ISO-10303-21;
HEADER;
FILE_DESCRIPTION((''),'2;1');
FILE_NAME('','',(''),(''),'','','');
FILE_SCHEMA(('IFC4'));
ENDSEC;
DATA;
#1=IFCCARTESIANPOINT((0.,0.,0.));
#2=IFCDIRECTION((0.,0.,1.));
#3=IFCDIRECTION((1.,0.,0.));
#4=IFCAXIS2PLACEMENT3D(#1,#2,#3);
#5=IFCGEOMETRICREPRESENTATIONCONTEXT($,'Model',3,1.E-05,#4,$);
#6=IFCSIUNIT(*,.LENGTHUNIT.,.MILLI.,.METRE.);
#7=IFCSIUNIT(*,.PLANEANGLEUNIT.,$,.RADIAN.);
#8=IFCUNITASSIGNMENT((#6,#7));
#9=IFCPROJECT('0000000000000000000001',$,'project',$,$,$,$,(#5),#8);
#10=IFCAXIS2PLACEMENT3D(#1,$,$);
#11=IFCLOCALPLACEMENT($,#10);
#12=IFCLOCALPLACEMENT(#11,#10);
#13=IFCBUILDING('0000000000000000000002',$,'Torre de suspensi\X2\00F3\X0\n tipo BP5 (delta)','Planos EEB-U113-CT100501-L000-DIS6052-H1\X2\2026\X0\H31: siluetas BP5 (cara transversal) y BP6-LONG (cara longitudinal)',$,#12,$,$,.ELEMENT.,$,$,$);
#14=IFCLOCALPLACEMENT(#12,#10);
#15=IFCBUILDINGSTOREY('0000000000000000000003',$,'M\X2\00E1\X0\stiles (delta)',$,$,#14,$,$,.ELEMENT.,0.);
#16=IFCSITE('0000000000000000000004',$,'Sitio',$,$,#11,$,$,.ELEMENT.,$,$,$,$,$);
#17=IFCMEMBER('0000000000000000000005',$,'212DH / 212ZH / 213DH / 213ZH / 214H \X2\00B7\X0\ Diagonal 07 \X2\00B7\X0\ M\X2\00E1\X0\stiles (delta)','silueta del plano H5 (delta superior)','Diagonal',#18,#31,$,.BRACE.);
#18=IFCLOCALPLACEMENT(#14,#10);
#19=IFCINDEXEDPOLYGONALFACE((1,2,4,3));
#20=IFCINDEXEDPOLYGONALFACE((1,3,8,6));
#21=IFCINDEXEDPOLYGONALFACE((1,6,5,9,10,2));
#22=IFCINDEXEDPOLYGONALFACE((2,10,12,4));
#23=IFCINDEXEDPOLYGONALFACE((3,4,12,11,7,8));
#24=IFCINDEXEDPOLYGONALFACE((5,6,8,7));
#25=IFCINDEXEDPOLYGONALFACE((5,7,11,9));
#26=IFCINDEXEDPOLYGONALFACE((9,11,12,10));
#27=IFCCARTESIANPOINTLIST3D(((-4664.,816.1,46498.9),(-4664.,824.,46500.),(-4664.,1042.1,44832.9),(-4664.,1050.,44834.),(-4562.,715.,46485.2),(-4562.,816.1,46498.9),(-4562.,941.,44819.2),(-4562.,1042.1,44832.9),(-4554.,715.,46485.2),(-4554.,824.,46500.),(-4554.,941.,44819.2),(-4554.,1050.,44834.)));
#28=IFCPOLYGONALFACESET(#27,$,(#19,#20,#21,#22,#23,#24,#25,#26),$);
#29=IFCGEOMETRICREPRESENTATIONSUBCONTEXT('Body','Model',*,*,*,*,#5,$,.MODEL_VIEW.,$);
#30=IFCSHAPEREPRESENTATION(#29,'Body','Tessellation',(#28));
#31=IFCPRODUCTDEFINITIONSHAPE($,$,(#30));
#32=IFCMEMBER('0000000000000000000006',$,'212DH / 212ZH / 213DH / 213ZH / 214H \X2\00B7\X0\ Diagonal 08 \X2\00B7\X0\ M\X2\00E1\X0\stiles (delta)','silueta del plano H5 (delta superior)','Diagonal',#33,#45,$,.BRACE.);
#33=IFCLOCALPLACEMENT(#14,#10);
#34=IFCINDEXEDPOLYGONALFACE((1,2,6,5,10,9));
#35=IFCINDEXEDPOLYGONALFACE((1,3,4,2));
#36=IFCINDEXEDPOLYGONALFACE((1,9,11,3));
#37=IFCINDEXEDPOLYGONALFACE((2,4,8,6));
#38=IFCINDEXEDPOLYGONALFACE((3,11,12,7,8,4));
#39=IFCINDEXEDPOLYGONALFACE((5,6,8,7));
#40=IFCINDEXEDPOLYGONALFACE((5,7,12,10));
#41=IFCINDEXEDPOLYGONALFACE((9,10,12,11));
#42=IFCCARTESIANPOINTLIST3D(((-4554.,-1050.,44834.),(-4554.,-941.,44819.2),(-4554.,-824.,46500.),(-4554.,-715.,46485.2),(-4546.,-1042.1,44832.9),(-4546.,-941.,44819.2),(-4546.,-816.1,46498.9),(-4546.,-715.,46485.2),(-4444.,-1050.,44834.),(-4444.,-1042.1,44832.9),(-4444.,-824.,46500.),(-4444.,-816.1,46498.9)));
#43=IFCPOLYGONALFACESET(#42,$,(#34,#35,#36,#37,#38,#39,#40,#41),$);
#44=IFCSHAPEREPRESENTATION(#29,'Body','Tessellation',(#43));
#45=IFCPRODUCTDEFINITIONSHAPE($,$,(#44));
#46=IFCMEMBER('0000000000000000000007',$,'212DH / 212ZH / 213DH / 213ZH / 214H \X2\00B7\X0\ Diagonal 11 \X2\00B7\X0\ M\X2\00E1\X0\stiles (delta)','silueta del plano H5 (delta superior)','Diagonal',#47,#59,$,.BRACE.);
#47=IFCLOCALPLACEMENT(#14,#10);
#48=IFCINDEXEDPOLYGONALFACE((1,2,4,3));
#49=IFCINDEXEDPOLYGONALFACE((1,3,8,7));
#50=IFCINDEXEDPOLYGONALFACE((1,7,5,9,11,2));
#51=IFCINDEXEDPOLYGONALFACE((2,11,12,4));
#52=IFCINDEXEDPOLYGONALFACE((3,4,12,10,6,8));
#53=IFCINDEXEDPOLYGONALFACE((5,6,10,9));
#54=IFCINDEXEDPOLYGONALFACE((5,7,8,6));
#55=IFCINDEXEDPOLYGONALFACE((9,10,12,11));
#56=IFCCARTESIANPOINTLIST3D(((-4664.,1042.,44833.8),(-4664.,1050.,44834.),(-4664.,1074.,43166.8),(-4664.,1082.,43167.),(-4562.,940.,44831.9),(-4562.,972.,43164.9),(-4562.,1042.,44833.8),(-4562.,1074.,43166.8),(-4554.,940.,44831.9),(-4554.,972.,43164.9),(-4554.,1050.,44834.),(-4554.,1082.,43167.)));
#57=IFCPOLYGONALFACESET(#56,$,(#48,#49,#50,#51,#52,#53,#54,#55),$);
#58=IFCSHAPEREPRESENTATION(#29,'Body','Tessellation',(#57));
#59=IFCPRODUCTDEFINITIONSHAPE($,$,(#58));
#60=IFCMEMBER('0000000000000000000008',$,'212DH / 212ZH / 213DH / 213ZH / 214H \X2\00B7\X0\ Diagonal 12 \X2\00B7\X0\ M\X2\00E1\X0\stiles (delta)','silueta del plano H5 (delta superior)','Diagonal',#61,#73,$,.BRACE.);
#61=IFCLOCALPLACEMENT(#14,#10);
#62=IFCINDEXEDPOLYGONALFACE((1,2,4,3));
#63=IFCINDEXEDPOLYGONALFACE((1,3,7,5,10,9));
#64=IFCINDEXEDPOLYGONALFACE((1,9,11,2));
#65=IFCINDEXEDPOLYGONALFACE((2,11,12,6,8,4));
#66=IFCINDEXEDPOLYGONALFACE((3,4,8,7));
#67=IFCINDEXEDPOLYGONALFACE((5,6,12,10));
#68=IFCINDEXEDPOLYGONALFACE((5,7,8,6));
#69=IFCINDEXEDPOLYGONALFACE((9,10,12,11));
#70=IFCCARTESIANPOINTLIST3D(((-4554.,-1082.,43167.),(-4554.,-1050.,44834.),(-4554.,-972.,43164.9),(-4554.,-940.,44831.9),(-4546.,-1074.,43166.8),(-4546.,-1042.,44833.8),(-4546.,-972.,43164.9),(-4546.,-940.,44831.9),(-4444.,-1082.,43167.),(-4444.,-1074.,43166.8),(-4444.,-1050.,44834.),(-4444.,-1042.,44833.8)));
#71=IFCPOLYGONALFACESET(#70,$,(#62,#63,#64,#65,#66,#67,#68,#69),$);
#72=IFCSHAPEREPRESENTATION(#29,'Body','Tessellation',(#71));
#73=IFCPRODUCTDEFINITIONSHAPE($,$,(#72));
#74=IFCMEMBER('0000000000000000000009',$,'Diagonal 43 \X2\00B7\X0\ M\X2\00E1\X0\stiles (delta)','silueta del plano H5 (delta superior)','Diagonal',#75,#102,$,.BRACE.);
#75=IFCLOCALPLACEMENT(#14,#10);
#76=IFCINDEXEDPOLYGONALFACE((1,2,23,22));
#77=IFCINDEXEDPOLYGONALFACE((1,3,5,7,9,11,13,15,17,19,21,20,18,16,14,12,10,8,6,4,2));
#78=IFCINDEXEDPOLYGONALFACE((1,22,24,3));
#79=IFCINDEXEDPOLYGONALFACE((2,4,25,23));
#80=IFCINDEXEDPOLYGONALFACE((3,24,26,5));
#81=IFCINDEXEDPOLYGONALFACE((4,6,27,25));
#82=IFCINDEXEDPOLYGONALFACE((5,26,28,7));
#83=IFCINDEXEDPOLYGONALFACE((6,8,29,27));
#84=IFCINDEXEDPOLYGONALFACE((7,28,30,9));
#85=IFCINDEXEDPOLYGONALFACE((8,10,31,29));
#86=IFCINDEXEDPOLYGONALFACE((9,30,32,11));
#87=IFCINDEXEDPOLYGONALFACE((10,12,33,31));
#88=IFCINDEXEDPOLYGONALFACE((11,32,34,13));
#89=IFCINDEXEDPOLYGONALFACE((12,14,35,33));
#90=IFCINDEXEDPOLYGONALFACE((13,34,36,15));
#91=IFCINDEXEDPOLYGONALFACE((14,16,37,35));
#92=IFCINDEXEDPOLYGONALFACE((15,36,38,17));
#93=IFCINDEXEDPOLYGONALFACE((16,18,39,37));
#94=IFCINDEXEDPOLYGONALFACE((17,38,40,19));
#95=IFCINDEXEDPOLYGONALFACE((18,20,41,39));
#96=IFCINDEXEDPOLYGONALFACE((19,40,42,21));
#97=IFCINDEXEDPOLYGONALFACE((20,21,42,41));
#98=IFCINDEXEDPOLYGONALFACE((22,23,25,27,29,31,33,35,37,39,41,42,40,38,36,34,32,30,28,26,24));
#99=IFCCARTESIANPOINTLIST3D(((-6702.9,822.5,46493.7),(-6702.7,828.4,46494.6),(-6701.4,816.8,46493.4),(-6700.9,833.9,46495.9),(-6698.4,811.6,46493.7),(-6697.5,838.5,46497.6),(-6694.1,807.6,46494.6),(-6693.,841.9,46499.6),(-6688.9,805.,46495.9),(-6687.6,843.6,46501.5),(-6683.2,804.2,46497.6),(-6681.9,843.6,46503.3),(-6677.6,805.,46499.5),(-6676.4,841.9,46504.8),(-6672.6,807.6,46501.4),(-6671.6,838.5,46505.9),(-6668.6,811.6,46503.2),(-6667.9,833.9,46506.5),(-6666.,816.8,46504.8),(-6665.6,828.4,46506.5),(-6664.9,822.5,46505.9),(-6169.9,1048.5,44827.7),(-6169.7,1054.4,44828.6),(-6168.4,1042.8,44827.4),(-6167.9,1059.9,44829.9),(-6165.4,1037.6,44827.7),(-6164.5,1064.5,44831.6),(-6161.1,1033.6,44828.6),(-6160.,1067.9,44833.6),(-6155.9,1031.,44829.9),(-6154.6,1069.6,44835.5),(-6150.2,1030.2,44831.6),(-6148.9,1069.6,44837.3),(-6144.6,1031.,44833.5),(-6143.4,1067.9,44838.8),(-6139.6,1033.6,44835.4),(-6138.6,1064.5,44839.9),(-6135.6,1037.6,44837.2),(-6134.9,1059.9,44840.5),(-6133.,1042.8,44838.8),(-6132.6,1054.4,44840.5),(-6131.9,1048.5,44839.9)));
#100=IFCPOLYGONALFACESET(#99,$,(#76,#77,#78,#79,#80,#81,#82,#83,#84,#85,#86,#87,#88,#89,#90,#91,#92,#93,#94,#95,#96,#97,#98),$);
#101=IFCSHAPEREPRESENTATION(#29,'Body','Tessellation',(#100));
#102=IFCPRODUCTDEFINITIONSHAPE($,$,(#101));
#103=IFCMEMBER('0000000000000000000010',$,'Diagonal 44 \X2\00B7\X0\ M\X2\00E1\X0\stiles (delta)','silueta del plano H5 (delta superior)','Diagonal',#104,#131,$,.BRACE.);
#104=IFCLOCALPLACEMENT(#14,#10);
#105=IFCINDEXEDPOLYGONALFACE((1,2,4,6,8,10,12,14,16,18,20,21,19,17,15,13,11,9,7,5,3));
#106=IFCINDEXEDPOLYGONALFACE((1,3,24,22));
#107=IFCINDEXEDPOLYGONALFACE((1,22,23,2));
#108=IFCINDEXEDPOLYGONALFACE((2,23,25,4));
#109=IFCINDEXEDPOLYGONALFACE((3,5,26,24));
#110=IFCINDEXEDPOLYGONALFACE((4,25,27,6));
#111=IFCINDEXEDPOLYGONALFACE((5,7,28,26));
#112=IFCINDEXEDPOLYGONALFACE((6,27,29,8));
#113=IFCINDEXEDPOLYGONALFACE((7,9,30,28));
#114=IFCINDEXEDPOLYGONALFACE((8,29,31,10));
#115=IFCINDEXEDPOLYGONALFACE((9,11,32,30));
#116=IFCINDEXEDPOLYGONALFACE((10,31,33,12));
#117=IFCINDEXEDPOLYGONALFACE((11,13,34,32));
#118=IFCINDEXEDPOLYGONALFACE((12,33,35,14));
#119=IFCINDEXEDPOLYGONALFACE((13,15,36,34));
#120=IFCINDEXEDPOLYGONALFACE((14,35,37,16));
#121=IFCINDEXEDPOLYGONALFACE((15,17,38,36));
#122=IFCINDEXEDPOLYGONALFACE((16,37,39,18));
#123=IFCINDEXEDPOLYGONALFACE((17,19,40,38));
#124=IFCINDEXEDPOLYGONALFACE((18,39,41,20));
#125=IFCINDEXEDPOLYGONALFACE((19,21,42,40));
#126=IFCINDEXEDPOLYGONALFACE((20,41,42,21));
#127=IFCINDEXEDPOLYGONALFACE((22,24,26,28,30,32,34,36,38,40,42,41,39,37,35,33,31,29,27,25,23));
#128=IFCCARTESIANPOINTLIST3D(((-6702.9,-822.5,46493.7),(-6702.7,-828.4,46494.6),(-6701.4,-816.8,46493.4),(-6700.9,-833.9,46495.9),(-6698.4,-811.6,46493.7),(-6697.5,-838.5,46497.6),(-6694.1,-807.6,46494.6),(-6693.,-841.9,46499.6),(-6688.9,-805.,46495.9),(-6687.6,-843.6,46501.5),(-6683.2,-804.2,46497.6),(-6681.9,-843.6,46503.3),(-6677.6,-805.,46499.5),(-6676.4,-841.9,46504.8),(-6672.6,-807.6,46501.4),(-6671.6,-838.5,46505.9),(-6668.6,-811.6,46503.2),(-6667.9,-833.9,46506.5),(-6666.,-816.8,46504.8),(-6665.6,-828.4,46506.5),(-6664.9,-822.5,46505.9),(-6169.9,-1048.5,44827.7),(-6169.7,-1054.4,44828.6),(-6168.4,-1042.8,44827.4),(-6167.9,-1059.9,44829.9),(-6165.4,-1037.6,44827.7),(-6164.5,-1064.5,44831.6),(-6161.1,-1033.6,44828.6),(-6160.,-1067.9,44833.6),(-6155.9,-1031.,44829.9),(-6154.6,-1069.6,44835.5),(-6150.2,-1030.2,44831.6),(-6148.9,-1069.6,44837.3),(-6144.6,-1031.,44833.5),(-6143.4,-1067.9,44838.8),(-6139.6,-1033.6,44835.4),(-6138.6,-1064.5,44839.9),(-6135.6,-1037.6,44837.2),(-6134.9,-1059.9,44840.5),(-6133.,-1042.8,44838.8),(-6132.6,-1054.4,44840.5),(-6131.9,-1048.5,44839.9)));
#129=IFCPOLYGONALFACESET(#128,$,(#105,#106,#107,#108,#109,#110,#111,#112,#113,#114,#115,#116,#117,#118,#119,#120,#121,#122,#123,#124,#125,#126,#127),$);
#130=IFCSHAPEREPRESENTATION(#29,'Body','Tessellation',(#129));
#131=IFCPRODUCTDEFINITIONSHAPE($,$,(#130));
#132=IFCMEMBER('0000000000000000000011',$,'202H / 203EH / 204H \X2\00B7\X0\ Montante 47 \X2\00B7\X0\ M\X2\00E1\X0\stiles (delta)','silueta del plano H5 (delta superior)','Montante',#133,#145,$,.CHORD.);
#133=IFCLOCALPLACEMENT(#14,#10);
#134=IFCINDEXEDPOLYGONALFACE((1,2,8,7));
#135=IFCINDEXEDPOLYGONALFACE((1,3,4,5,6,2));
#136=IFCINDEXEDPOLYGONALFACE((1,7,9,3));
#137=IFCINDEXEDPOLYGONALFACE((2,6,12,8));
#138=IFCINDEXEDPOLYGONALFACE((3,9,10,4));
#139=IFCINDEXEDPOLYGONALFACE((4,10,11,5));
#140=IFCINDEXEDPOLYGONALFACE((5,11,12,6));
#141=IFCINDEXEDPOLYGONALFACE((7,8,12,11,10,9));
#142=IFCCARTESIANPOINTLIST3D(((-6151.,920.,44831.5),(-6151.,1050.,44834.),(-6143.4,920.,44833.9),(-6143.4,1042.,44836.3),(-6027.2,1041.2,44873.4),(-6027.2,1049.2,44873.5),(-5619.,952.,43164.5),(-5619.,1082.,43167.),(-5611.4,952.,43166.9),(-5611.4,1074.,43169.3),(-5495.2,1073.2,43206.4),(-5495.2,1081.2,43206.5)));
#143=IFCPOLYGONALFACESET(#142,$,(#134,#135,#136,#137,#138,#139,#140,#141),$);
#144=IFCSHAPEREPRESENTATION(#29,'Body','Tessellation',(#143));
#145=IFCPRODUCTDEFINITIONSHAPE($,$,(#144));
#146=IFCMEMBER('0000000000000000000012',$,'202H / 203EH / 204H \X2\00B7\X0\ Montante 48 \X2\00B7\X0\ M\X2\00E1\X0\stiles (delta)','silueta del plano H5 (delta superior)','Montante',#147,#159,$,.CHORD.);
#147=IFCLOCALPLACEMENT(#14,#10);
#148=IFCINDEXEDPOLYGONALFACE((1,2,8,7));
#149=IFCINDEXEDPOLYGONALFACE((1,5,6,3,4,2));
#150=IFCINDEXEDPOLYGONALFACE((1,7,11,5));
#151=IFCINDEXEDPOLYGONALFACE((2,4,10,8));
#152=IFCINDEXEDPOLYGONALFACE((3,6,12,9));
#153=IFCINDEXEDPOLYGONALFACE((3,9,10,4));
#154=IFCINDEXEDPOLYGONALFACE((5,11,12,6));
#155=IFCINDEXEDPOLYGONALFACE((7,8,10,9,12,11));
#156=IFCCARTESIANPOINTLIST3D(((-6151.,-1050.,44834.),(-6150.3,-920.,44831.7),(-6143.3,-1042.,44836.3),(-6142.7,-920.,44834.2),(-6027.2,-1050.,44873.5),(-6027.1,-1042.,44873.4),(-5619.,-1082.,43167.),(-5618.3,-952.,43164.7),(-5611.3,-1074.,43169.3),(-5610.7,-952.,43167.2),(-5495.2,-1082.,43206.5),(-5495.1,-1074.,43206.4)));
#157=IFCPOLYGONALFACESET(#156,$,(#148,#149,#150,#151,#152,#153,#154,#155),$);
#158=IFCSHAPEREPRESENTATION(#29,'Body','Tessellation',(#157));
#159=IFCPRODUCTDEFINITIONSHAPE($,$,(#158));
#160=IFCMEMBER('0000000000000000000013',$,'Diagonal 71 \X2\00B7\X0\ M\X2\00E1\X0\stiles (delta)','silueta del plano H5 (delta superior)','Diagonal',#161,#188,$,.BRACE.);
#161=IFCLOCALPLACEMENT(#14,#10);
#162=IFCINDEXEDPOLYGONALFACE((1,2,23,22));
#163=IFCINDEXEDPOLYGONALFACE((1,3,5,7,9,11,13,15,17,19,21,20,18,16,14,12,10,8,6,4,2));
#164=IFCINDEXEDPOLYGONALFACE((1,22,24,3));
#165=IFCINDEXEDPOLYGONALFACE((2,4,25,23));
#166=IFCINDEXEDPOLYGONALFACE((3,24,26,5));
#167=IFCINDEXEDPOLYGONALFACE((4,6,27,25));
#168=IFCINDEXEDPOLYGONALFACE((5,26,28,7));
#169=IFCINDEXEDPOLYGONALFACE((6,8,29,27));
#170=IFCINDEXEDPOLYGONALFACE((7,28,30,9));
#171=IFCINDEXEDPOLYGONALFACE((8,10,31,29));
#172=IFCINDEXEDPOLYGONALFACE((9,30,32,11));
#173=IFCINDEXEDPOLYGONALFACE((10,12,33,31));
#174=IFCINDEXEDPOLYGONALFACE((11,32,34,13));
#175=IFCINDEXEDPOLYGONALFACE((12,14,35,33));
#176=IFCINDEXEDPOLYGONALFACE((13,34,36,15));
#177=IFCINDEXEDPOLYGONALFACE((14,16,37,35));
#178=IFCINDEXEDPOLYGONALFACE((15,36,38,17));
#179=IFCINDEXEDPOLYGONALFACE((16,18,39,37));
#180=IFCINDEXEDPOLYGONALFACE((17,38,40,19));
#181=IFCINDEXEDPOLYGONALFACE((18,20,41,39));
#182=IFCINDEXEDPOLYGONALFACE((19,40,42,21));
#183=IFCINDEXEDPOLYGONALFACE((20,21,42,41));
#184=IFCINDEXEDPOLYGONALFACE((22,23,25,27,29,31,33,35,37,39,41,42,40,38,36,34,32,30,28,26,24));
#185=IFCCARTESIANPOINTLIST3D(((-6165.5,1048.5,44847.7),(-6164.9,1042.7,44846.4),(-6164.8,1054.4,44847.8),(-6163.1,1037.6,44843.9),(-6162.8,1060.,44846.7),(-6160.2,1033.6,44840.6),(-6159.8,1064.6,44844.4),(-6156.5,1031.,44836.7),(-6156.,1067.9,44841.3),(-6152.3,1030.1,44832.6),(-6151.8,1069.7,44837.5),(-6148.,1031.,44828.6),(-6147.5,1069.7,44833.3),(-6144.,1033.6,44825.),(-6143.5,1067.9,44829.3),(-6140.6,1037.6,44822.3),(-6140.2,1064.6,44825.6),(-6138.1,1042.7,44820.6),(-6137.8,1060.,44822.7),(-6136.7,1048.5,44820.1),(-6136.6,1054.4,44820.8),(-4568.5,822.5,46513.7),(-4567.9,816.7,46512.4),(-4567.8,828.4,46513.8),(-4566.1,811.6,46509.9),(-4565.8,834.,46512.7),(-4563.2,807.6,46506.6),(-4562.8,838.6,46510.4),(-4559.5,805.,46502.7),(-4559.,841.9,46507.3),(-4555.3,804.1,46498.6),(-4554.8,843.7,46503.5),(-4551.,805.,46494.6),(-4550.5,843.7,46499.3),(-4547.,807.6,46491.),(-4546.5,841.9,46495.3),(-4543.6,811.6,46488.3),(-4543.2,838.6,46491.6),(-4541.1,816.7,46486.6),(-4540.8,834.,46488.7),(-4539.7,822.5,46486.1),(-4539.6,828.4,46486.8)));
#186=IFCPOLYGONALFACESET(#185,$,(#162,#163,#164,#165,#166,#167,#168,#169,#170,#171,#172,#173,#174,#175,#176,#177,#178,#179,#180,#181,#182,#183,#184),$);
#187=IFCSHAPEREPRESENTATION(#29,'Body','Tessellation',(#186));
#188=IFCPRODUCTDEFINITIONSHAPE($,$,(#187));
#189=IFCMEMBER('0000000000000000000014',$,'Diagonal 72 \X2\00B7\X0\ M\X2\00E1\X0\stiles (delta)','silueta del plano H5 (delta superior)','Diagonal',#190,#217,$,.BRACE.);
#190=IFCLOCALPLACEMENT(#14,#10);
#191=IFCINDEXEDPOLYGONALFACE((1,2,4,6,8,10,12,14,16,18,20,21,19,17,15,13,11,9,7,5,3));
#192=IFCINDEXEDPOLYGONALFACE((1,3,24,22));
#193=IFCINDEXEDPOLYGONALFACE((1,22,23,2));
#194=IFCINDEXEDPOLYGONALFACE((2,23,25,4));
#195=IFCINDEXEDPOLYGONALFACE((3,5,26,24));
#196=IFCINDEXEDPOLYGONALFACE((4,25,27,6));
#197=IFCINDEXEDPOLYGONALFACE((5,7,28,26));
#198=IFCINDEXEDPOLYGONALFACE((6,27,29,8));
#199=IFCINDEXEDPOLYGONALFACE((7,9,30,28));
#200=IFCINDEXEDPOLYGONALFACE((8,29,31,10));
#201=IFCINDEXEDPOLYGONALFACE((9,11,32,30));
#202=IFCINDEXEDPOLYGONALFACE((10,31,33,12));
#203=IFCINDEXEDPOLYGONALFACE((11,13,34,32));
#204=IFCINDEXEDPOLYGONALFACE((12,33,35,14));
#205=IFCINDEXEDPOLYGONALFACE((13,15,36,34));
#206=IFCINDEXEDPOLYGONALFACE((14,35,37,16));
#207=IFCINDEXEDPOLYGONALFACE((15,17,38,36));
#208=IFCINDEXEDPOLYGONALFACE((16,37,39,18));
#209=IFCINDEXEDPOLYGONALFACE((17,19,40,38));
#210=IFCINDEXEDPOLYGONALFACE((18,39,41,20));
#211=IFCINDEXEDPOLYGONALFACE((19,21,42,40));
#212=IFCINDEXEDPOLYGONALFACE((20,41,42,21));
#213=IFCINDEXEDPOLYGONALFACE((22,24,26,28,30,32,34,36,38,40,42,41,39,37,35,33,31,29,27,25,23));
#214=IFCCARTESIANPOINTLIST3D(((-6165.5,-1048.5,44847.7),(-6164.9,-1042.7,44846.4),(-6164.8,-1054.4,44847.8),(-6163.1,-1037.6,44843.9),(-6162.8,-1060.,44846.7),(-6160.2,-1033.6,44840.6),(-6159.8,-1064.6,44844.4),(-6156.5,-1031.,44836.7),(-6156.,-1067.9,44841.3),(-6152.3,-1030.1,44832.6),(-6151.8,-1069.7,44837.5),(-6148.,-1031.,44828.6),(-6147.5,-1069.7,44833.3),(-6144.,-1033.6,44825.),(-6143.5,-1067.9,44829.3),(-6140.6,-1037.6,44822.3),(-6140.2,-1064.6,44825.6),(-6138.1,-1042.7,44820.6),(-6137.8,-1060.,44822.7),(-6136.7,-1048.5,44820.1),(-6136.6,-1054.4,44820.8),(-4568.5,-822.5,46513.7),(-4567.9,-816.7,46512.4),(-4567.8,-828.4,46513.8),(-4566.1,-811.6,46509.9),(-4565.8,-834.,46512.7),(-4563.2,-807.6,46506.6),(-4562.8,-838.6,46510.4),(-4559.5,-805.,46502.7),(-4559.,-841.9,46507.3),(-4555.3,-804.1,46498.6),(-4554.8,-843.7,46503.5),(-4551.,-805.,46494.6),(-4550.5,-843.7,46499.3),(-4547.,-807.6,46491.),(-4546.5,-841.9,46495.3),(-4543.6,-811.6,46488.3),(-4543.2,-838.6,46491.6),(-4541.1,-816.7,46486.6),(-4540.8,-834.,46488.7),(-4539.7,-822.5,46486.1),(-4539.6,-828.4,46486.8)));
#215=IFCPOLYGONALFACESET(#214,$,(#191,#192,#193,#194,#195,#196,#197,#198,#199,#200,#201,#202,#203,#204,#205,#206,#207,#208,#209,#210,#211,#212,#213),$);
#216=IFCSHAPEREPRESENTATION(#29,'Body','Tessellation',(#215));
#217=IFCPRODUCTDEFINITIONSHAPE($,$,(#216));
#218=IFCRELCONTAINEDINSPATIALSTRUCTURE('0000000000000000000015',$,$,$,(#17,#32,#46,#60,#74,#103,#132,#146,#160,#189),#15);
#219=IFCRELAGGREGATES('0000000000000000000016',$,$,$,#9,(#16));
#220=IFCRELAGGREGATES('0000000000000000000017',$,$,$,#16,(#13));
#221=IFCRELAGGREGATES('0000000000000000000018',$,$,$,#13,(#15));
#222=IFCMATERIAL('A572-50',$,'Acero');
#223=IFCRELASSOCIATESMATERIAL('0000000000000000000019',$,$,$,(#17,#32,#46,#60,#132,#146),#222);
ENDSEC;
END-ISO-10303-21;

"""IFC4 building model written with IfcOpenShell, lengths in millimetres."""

from ifc_helpers import new_model, si_unit, frame, frame_2d, origin, origin_with_axes, place, context, subcontext, project, spatial, circle, l_section, extrude, material, element, save


model = new_model("IFC4")

# Units and contexts
model_context = context("Model", 3, precision=1e-05, world=origin_with_axes())
body_context = subcontext(model_context, "Body", "Model", "MODEL_VIEW")
ifc_project = project(units=[si_unit("LENGTHUNIT", "METRE", prefix="MILLI"), si_unit("PLANEANGLEUNIT", "RADIAN")], contexts=[model_context])

# Site, building, storey
site_placement = place(None, origin())
site = spatial("IfcSite", under=ifc_project, at=site_placement, Name="Sitio", CompositionType="ELEMENT")
building_placement = place(site_placement, origin())
building = spatial("IfcBuilding", under=site, at=building_placement, Name="Torre de suspensión tipo BP5 (delta)", Description="Planos EEB-U113-CT100501-L000-DIS6052-H1…H31: siluetas BP5 (cara transversal) y BP6-LONG (cara longitudinal)", CompositionType="ELEMENT")
storey_placement = place(building_placement, origin())
storey = spatial("IfcBuildingStorey", under=building, at=storey_placement, Name="Mástiles (delta)", CompositionType="ELEMENT", Elevation=0.0)

# Members
ifc_material = material(Name="A572-50", Category="Acero")
for number, where, z_axis, x_axis, name in (
    (1, (-4554.0, 824.0, 46500.0), (0.0, 0.134423, -0.990924), (0.0, -0.990924, -0.134423), "212DH / 212ZH / 213DH / 213ZH / 214H · Diagonal 07 · Mástiles (delta)"),
    (2, (-4554.0, -824.0, 46500.0), (0.0, -0.134423, -0.990924), (0.0, 0.990924, -0.134423), "212DH / 212ZH / 213DH / 213ZH / 214H · Diagonal 08 · Mástiles (delta)"),
):
    element("IfcMember", number, at=place(storey_placement, frame(where, z_axis=z_axis, x_axis=x_axis)), inside=storey, material=ifc_material, Name=name, Description="silueta del plano H5 (delta superior)", ObjectType="Diagonal", PredefinedType="BRACE", context=body_context, shape_type="SweptSolid", body=[
        extrude(l_section(Depth=110.0, Width=110.0, Thickness=8.0, at=frame_2d((55.0, 55.0))), None, (0.0, 0.0, 1.0), 1681.3),
    ])
for number, where, z_axis, x_axis, name in (
    (3, (-4554.0, 1050.0, 44834.0), (0.0, 0.019193, -0.999816), (0.0, -0.999816, -0.019193), "212DH / 212ZH / 213DH / 213ZH / 214H · Diagonal 11 · Mástiles (delta)"),
    (4, (-4554.0, -1050.0, 44834.0), (0.0, -0.019193, -0.999816), (0.0, 0.999816, -0.019193), "212DH / 212ZH / 213DH / 213ZH / 214H · Diagonal 12 · Mástiles (delta)"),
):
    element("IfcMember", number, at=place(storey_placement, frame(where, z_axis=z_axis, x_axis=x_axis)), inside=storey, material=ifc_material, Name=name, Description="silueta del plano H5 (delta superior)", ObjectType="Diagonal", PredefinedType="BRACE", context=body_context, shape_type="SweptSolid", body=[
        extrude(l_section(Depth=110.0, Width=110.0, Thickness=8.0, at=frame_2d((55.0, 55.0))), None, (0.0, 0.0, 1.0), 1667.3),
    ])
for number, where, z_axis, x_axis, name in (
    (5, (-6684.0, 824.0, 46500.0), (0.302202, 0.128138, -0.944592), (0.039045, -0.991756, -0.122044), "Diagonal 43 · Mástiles (delta)"),
    (6, (-6684.0, -824.0, 46500.0), (0.302202, -0.128138, -0.944592), (0.039045, 0.991756, -0.122044), "Diagonal 44 · Mástiles (delta)"),
):
    element("IfcMember", number, at=place(storey_placement, frame(where, z_axis=z_axis, x_axis=x_axis)), inside=storey, Name=name, Description="silueta del plano H5 (delta superior)", ObjectType="Diagonal", PredefinedType="BRACE", context=body_context, shape_type="SweptSolid", body=[
        extrude(circle(Radius=20.0), None, (0.0, 0.0, 1.0), 1763.7),
    ])
for number, where, z_axis, x_axis, name in (
    (7, (-6151.0, 1050.0, 44834.0), (0.303978, 0.018284, -0.952503), (0.952679, -0.005834, 0.303922), "202H / 203EH / 204H · Montante 47 · Mástiles (delta)"),
    (8, (-6151.0, -1050.0, 44834.0), (0.303978, -0.018284, -0.952503), (0.005559, 0.999833, -0.017419), "202H / 203EH / 204H · Montante 48 · Mástiles (delta)"),
):
    element("IfcMember", number, at=place(storey_placement, frame(where, z_axis=z_axis, x_axis=x_axis)), inside=storey, material=ifc_material, Name=name, Description="silueta del plano H5 (delta superior)", ObjectType="Montante", PredefinedType="CHORD", context=body_context, shape_type="SweptSolid", body=[
        extrude(l_section(Depth=130.0, Width=130.0, Thickness=8.0, at=frame_2d((65.0, 65.0))), None, (0.0, 0.0, 1.0), 1750.1),
    ])
for number, where, z_axis, x_axis, name in (
    (9, (-4554.0, 824.0, 46500.0), (-0.688705, 0.097462, -0.718461), (-0.067444, -0.995239, -0.070358), "Diagonal 71 · Mástiles (delta)"),
    (10, (-4554.0, -824.0, 46500.0), (-0.688705, -0.097462, -0.718461), (-0.067444, 0.995239, -0.070358), "Diagonal 72 · Mástiles (delta)"),
):
    element("IfcMember", number, at=place(storey_placement, frame(where, z_axis=z_axis, x_axis=x_axis)), inside=storey, Name=name, Description="silueta del plano H5 (delta superior)", ObjectType="Diagonal", PredefinedType="BRACE", context=body_context, shape_type="SweptSolid", body=[
        extrude(circle(Radius=20.0), None, (0.0, 0.0, 1.0), 2318.8),
    ])

save(model, "model.ifc")
